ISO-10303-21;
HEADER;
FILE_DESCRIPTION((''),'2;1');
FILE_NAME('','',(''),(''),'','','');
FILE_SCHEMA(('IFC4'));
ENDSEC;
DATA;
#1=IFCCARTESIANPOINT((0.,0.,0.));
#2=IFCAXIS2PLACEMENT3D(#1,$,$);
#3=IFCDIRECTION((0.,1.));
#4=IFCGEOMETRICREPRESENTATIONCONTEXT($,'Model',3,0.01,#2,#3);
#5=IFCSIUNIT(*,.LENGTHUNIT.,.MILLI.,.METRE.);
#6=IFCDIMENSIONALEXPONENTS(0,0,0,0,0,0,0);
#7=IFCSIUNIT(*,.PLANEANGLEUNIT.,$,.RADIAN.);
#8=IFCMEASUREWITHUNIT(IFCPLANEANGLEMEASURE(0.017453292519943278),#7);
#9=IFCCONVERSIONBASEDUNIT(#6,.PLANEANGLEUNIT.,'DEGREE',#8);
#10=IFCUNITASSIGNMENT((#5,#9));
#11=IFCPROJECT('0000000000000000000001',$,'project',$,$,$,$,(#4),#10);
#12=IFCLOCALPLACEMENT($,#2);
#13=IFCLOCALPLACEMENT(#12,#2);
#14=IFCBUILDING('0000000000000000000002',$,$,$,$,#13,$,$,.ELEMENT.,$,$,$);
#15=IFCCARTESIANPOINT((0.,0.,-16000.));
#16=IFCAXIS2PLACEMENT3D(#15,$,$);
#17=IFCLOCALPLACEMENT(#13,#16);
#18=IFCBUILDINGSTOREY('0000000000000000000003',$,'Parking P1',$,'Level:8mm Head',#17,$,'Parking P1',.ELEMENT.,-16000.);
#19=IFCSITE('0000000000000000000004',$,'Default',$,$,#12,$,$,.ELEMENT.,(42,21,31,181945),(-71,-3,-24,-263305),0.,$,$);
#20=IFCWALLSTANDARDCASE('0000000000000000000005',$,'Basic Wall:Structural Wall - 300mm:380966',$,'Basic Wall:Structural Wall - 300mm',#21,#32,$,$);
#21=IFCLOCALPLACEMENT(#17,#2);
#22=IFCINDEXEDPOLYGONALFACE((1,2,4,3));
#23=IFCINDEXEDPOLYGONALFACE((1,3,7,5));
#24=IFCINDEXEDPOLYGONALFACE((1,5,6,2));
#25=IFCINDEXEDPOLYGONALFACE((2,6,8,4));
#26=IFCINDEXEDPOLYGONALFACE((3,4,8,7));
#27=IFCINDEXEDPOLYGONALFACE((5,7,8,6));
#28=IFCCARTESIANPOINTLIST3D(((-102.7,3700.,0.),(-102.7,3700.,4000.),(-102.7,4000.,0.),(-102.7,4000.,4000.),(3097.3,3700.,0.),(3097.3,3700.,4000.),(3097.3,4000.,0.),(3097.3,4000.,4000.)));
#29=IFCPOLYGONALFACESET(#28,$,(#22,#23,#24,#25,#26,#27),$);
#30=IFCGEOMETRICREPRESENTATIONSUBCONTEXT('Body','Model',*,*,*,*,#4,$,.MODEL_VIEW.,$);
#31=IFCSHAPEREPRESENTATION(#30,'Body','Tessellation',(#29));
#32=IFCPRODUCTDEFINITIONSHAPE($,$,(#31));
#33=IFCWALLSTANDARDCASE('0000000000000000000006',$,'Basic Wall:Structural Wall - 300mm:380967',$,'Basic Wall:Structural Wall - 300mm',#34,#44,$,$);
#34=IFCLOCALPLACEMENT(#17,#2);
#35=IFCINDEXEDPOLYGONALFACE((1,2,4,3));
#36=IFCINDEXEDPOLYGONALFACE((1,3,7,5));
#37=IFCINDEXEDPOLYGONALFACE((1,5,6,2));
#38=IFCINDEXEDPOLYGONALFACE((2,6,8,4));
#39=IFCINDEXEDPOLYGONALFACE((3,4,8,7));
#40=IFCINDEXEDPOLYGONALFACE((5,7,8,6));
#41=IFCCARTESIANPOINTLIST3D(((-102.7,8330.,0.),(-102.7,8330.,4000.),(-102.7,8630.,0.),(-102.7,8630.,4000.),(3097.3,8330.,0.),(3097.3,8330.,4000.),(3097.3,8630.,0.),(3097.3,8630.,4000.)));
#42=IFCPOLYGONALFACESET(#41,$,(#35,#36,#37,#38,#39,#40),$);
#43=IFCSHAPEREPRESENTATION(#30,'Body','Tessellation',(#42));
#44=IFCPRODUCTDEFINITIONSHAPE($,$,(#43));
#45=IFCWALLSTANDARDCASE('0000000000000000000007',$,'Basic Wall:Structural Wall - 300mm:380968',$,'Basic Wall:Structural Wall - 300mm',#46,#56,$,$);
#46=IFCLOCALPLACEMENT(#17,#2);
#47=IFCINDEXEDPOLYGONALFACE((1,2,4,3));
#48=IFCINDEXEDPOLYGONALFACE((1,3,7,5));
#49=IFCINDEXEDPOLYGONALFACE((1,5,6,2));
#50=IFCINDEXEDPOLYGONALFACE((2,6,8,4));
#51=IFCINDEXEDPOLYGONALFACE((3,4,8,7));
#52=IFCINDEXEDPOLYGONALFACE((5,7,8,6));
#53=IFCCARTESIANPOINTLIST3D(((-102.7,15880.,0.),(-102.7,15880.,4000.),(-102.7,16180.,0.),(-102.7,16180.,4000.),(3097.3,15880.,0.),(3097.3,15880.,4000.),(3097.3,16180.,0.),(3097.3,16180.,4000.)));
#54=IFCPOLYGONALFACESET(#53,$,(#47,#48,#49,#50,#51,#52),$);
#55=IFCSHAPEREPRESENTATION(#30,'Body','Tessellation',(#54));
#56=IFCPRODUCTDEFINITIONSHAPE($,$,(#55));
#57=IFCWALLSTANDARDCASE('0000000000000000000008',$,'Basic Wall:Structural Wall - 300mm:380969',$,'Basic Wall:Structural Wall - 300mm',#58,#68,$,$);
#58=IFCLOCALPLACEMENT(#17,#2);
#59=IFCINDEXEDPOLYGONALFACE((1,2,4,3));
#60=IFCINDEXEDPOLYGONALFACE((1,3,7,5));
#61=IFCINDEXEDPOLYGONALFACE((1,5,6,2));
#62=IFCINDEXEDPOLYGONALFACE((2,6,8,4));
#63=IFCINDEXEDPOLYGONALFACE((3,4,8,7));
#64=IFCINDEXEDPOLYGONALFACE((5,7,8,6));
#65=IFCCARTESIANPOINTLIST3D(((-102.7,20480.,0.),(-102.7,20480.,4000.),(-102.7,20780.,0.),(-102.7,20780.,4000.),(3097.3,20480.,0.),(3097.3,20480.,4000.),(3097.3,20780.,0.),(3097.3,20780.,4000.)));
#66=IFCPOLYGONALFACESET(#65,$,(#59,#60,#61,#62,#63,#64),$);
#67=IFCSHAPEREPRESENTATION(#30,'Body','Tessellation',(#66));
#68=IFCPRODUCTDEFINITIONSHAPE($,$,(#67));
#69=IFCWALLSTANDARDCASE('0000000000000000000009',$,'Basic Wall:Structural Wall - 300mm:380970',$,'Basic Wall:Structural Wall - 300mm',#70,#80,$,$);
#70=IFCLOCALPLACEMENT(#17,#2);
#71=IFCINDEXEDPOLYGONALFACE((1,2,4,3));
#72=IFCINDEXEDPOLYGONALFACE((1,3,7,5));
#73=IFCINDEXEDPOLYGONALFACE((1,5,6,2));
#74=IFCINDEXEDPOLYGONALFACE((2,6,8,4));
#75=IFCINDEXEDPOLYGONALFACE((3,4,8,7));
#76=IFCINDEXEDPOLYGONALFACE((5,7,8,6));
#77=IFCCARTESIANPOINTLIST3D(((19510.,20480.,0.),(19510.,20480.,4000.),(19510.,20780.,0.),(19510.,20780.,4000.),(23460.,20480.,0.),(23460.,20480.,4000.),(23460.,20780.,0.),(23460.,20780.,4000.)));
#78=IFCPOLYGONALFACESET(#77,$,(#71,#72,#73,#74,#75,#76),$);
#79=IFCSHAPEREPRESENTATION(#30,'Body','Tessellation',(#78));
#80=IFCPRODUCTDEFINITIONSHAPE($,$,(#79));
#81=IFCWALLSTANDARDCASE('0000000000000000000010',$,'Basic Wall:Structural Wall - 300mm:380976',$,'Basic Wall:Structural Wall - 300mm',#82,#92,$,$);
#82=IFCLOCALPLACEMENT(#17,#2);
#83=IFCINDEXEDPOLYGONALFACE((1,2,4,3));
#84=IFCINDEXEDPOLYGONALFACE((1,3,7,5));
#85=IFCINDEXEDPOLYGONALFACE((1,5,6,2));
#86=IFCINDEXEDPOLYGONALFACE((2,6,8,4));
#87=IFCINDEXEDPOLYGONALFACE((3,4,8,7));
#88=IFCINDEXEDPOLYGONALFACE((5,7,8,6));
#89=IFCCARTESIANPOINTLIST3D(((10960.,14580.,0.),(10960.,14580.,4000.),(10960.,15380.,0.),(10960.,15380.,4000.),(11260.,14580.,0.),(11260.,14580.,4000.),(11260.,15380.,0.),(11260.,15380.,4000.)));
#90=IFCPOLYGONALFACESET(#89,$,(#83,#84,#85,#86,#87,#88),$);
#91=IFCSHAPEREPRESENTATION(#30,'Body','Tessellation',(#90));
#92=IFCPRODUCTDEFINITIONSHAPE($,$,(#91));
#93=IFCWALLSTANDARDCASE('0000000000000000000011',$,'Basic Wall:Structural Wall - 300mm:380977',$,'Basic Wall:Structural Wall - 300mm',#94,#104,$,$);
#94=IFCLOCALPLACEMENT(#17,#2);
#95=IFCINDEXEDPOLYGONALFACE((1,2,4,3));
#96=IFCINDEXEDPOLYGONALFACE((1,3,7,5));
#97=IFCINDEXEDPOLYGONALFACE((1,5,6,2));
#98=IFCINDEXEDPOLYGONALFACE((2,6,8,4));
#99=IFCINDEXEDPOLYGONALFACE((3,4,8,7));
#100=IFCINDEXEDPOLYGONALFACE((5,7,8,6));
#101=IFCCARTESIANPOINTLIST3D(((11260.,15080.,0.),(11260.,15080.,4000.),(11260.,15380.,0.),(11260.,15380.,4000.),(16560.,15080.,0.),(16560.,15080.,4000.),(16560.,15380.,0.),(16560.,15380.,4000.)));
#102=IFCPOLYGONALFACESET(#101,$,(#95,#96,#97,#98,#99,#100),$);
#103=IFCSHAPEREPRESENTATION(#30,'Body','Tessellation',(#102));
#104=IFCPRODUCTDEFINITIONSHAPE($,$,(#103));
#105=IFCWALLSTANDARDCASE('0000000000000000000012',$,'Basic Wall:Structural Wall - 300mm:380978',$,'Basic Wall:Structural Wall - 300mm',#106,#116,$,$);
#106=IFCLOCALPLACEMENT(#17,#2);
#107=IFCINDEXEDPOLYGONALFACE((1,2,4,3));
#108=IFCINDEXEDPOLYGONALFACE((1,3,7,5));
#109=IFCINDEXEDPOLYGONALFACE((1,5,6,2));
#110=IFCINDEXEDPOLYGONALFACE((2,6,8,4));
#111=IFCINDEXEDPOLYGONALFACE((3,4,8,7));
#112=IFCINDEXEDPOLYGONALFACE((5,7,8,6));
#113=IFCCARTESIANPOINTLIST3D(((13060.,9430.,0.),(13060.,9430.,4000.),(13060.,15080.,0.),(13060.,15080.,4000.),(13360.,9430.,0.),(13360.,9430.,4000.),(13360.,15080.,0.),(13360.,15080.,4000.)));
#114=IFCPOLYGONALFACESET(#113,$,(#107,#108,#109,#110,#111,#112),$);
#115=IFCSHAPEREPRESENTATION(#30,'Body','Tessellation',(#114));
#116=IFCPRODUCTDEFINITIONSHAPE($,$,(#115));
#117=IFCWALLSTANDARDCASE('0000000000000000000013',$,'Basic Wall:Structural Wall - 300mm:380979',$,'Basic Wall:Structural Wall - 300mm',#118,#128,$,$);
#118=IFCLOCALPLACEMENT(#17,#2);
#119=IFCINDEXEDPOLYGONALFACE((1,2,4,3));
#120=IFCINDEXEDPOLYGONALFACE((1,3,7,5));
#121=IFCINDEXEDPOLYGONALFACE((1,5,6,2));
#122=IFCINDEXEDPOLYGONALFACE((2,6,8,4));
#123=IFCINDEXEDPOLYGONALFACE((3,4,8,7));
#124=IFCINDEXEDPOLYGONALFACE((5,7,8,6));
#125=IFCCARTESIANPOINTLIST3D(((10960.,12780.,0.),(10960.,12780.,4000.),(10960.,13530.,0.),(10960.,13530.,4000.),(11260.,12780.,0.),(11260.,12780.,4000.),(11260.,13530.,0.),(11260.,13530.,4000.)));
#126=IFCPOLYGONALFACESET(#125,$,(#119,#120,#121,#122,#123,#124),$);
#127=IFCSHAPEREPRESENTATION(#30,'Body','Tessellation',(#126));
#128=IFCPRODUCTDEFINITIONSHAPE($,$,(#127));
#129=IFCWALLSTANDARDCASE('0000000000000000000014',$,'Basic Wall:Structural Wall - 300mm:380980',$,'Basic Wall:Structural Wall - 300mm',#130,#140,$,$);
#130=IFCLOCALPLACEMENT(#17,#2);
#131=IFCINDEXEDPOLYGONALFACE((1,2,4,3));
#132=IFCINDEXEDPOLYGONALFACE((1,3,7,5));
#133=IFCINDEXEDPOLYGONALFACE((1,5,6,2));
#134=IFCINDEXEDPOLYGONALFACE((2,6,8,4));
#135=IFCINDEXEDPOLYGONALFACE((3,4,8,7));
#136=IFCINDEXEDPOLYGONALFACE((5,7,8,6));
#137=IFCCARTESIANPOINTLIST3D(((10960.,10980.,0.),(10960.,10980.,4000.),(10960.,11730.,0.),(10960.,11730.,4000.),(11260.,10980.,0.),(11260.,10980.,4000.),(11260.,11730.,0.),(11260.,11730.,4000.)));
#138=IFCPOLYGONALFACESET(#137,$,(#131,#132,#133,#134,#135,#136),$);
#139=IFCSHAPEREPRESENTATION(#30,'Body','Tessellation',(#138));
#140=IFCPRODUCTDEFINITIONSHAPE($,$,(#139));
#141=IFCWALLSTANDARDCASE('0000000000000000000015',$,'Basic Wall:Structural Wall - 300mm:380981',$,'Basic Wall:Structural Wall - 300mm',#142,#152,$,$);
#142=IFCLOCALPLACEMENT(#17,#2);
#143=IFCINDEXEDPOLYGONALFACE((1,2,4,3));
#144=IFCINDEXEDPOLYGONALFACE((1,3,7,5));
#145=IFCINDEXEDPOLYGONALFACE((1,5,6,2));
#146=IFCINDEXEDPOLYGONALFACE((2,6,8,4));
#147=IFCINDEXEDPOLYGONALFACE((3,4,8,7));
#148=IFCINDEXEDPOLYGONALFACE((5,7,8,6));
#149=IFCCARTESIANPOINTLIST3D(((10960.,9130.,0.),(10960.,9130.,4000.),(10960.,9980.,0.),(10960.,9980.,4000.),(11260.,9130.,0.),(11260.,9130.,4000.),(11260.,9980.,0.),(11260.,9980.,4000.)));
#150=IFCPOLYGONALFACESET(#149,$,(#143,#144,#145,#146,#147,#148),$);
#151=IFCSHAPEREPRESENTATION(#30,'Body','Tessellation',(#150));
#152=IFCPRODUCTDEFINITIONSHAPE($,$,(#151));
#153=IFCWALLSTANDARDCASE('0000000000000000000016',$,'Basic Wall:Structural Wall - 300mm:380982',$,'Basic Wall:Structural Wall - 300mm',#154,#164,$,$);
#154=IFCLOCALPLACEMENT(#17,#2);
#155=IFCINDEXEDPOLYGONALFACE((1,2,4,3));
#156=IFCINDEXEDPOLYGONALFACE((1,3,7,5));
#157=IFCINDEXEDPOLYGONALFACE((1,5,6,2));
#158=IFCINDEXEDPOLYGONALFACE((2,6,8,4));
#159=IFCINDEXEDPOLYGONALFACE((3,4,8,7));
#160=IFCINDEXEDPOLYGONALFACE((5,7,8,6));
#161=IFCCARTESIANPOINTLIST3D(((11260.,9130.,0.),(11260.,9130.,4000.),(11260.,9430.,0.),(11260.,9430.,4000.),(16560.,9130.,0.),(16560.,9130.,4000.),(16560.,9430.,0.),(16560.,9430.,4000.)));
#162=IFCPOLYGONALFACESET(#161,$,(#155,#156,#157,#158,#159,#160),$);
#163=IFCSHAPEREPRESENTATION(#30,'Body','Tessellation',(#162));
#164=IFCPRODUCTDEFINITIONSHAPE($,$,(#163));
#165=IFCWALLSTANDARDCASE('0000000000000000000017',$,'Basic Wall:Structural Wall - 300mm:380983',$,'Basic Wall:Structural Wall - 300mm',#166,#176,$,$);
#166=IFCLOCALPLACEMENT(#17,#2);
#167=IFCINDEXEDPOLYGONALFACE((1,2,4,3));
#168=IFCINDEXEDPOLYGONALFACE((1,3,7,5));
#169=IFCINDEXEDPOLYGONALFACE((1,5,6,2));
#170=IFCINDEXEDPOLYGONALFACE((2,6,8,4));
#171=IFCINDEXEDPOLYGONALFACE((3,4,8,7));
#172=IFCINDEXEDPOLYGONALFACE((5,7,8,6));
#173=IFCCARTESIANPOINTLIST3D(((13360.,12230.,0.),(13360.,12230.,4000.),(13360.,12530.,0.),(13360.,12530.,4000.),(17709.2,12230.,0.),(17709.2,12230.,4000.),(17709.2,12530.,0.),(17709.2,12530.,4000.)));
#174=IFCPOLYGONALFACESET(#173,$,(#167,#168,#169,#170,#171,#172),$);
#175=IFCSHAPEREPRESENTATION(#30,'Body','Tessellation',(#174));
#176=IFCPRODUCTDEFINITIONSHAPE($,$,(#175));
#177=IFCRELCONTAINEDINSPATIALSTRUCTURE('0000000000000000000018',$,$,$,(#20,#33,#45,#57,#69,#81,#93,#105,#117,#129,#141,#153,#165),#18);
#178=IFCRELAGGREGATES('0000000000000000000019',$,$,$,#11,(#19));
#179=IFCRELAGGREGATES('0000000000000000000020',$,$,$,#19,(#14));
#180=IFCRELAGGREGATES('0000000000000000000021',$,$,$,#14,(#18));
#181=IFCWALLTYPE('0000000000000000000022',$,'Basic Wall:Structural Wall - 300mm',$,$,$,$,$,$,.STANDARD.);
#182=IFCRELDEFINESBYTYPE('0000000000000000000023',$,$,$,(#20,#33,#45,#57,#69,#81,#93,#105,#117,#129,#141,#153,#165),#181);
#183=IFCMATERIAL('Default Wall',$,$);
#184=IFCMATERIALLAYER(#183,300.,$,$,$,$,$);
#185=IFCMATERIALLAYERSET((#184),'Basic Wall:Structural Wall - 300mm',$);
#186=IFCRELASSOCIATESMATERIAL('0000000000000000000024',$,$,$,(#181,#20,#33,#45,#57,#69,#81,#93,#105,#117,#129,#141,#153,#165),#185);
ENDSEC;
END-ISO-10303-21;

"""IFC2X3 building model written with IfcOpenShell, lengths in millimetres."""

from ifc_helpers import new_model, entity, si_unit, converted_unit, direction, frame, frame_2d, origin, place, context, subcontext, project, spatial, rectangle, extrude, material, layer, layer_set, layer_usage, type_object, element, save


model = new_model("IFC2X3")

# Units and contexts
model_context = context("Model", 3, precision=0.01, world=origin(), true_north=direction((0.0, 1.0)))
body_context = subcontext(model_context, "Body", "Model", "MODEL_VIEW")
ifc_project = project(units=[si_unit("LENGTHUNIT", "METRE", prefix="MILLI"), converted_unit("PLANEANGLEUNIT", "DEGREE", entity("IfcPlaneAngleMeasure", 0.017453292519943278), si_unit("PLANEANGLEUNIT", "RADIAN"), dimensions=[0, 0, 0, 0, 0, 0, 0])], contexts=[model_context])

# Site, building, storey
site_placement = place(None, origin())
site = spatial("IfcSite", under=ifc_project, at=site_placement, Name="Default", CompositionType="ELEMENT", RefLatitude=(42, 21, 31, 181945), RefLongitude=(-71, -3, -24, -263305), RefElevation=0.0)
building_placement = place(site_placement, origin())
building = spatial("IfcBuilding", under=site, at=building_placement, CompositionType="ELEMENT")
storey_placement = place(building_placement, frame((0.0, 0.0, -16000.0)))
storey = spatial("IfcBuildingStorey", under=building, at=storey_placement, Name="Parking P1", ObjectType="Level:8mm Head", LongName="Parking P1", CompositionType="ELEMENT", Elevation=-16000.0)

# Walls
ifc_material_1 = material(Name="Default Wall")
ifc_layer_1 = layer(ifc_material_1, 300.0)
ifc_layer_set_1 = layer_set([ifc_layer_1], Name="Basic Wall:Structural Wall - 300mm")
ifc_layer_usage_1 = layer_usage(ifc_layer_set_1, "AXIS2", "NEGATIVE", 150.0)
wall_type_1 = type_object("IfcWallType", Name="Basic Wall:Structural Wall - 300mm", PredefinedType="STANDARD", material=ifc_layer_set_1)
wall_1_placement = place(storey_placement, frame((3097.3, 3850.0, 0.0), z_axis=(0.0, 0.0, 1.0), x_axis=(-1.0, 0.0, 0.0)))
element("IfcWallStandardCase", 1, at=wall_1_placement, inside=storey, type_object=wall_type_1, material=ifc_layer_usage_1, Name="Basic Wall:Structural Wall - 300mm:380966", ObjectType="Basic Wall:Structural Wall - 300mm", context=body_context, shape_type="SweptSolid", body=[
    extrude(rectangle(XDim=3200.0, YDim=300.0, at=frame_2d((1600.0, 0.0), x_axis=(-1.0, 0.0))), origin(), (0.0, 0.0, 1.0), 4000.0),
])
ifc_layer_usage_2 = layer_usage(ifc_layer_set_1, "AXIS2", "NEGATIVE", 150.0)
wall_2_placement = place(storey_placement, frame((-102.7, 8480.0, 0.0)))
element("IfcWallStandardCase", 2, at=wall_2_placement, inside=storey, type_object=wall_type_1, material=ifc_layer_usage_2, Name="Basic Wall:Structural Wall - 300mm:380967", ObjectType="Basic Wall:Structural Wall - 300mm", context=body_context, shape_type="SweptSolid", body=[
    extrude(rectangle(XDim=3200.0, YDim=300.0, at=frame_2d((1600.0, 0.0), x_axis=(-1.0, 0.0))), origin(), (0.0, 0.0, 1.0), 4000.0),
])
ifc_layer_usage_3 = layer_usage(ifc_layer_set_1, "AXIS2", "NEGATIVE", 150.0)
wall_3_placement = place(storey_placement, frame((-102.7, 16030.0, 0.0)))
element("IfcWallStandardCase", 3, at=wall_3_placement, inside=storey, type_object=wall_type_1, material=ifc_layer_usage_3, Name="Basic Wall:Structural Wall - 300mm:380968", ObjectType="Basic Wall:Structural Wall - 300mm", context=body_context, shape_type="SweptSolid", body=[
    extrude(rectangle(XDim=3200.0, YDim=300.0, at=frame_2d((1600.0, 0.0), x_axis=(-1.0, 0.0))), origin(), (0.0, 0.0, 1.0), 4000.0),
])
ifc_layer_usage_4 = layer_usage(ifc_layer_set_1, "AXIS2", "NEGATIVE", 150.0)
wall_4_placement = place(storey_placement, frame((-102.7, 20630.0, 0.0)))
element("IfcWallStandardCase", 4, at=wall_4_placement, inside=storey, type_object=wall_type_1, material=ifc_layer_usage_4, Name="Basic Wall:Structural Wall - 300mm:380969", ObjectType="Basic Wall:Structural Wall - 300mm", context=body_context, shape_type="SweptSolid", body=[
    extrude(rectangle(XDim=3200.0, YDim=300.0, at=frame_2d((1600.0, 0.0), x_axis=(-1.0, 0.0))), origin(), (0.0, 0.0, 1.0), 4000.0),
])
ifc_layer_usage_5 = layer_usage(ifc_layer_set_1, "AXIS2", "NEGATIVE", 150.0)
wall_5_placement = place(storey_placement, frame((19510.0, 20630.0, 0.0)))
element("IfcWallStandardCase", 5, at=wall_5_placement, inside=storey, type_object=wall_type_1, material=ifc_layer_usage_5, Name="Basic Wall:Structural Wall - 300mm:380970", ObjectType="Basic Wall:Structural Wall - 300mm", context=body_context, shape_type="SweptSolid", body=[
    extrude(rectangle(XDim=3950.0, YDim=300.0, at=frame_2d((1975.0, 0.0), x_axis=(-1.0, 0.0))), origin(), (0.0, 0.0, 1.0), 4000.0),
])
ifc_layer_usage_6 = layer_usage(ifc_layer_set_1, "AXIS2", "NEGATIVE", 150.0)
wall_6_placement = place(storey_placement, frame((11110.0, 14580.0, 0.0), z_axis=(0.0, 0.0, 1.0), x_axis=(0.0, 1.0, 0.0)))
element("IfcWallStandardCase", 6, at=wall_6_placement, inside=storey, type_object=wall_type_1, material=ifc_layer_usage_6, Name="Basic Wall:Structural Wall - 300mm:380976", ObjectType="Basic Wall:Structural Wall - 300mm", context=body_context, shape_type="SweptSolid", body=[
    extrude(rectangle(XDim=800.0, YDim=300.0, at=frame_2d((400.0, 0.0), x_axis=(-1.0, 0.0))), origin(), (0.0, 0.0, 1.0), 4000.0),
])
ifc_layer_usage_7 = layer_usage(ifc_layer_set_1, "AXIS2", "NEGATIVE", 150.0)
wall_7_placement = place(storey_placement, frame((11260.0, 15230.0, 0.0)))
element("IfcWallStandardCase", 7, at=wall_7_placement, inside=storey, type_object=wall_type_1, material=ifc_layer_usage_7, Name="Basic Wall:Structural Wall - 300mm:380977", ObjectType="Basic Wall:Structural Wall - 300mm", context=body_context, shape_type="SweptSolid", body=[
    extrude(rectangle(XDim=5300.0, YDim=300.0, at=frame_2d((2650.0, 0.0), x_axis=(-1.0, 0.0))), origin(), (0.0, 0.0, 1.0), 4000.0),
])
ifc_layer_usage_8 = layer_usage(ifc_layer_set_1, "AXIS2", "NEGATIVE", 150.0)
wall_8_placement = place(storey_placement, frame((13210.0, 15080.0, 0.0), z_axis=(0.0, 0.0, 1.0), x_axis=(0.0, -1.0, 0.0)))
element("IfcWallStandardCase", 8, at=wall_8_placement, inside=storey, type_object=wall_type_1, material=ifc_layer_usage_8, Name="Basic Wall:Structural Wall - 300mm:380978", ObjectType="Basic Wall:Structural Wall - 300mm", context=body_context, shape_type="SweptSolid", body=[
    extrude(rectangle(XDim=5650.0, YDim=300.0, at=frame_2d((2825.0, 0.0), x_axis=(-1.0, 0.0))), origin(), (0.0, 0.0, 1.0), 4000.0),
])
ifc_layer_usage_9 = layer_usage(ifc_layer_set_1, "AXIS2", "NEGATIVE", 150.0)
wall_9_placement = place(storey_placement, frame((11110.0, 13530.0, 0.0), z_axis=(0.0, 0.0, 1.0), x_axis=(0.0, -1.0, 0.0)))
element("IfcWallStandardCase", 9, at=wall_9_placement, inside=storey, type_object=wall_type_1, material=ifc_layer_usage_9, Name="Basic Wall:Structural Wall - 300mm:380979", ObjectType="Basic Wall:Structural Wall - 300mm", context=body_context, shape_type="SweptSolid", body=[
    extrude(rectangle(XDim=750.0, YDim=300.0, at=frame_2d((375.0, 0.0), x_axis=(-1.0, 0.0))), origin(), (0.0, 0.0, 1.0), 4000.0),
])
ifc_layer_usage_10 = layer_usage(ifc_layer_set_1, "AXIS2", "NEGATIVE", 150.0)
wall_10_placement = place(storey_placement, frame((11110.0, 11730.0, 0.0), z_axis=(0.0, 0.0, 1.0), x_axis=(0.0, -1.0, 0.0)))
element("IfcWallStandardCase", 10, at=wall_10_placement, inside=storey, type_object=wall_type_1, material=ifc_layer_usage_10, Name="Basic Wall:Structural Wall - 300mm:380980", ObjectType="Basic Wall:Structural Wall - 300mm", context=body_context, shape_type="SweptSolid", body=[
    extrude(rectangle(XDim=750.0, YDim=300.0, at=frame_2d((375.0, 0.0), x_axis=(-1.0, 0.0))), origin(), (0.0, 0.0, 1.0), 4000.0),
])
ifc_layer_usage_11 = layer_usage(ifc_layer_set_1, "AXIS2", "NEGATIVE", 150.0)
wall_11_placement = place(storey_placement, frame((11110.0, 9980.0, 0.0), z_axis=(0.0, 0.0, 1.0), x_axis=(0.0, -1.0, 0.0)))
element("IfcWallStandardCase", 11, at=wall_11_placement, inside=storey, type_object=wall_type_1, material=ifc_layer_usage_11, Name="Basic Wall:Structural Wall - 300mm:380981", ObjectType="Basic Wall:Structural Wall - 300mm", context=body_context, shape_type="SweptSolid", body=[
    extrude(rectangle(XDim=850.0, YDim=300.0, at=frame_2d((425.0, 0.0), x_axis=(-1.0, 0.0))), origin(), (0.0, 0.0, 1.0), 4000.0),
])
ifc_layer_usage_12 = layer_usage(ifc_layer_set_1, "AXIS2", "NEGATIVE", 150.0)
wall_12_placement = place(storey_placement, frame((11260.0, 9280.0, 0.0)))
element("IfcWallStandardCase", 12, at=wall_12_placement, inside=storey, type_object=wall_type_1, material=ifc_layer_usage_12, Name="Basic Wall:Structural Wall - 300mm:380982", ObjectType="Basic Wall:Structural Wall - 300mm", context=body_context, shape_type="SweptSolid", body=[
    extrude(rectangle(XDim=5300.0, YDim=300.0, at=frame_2d((2650.0, 0.0), x_axis=(-1.0, 0.0))), origin(), (0.0, 0.0, 1.0), 4000.0),
])
ifc_layer_usage_13 = layer_usage(ifc_layer_set_1, "AXIS2", "NEGATIVE", 150.0)
wall_13_placement = place(storey_placement, frame((13360.0, 12380.0, 0.0)))
element("IfcWallStandardCase", 13, at=wall_13_placement, inside=storey, type_object=wall_type_1, material=ifc_layer_usage_13, Name="Basic Wall:Structural Wall - 300mm:380983", ObjectType="Basic Wall:Structural Wall - 300mm", context=body_context, shape_type="SweptSolid", body=[
    extrude(rectangle(XDim=4349.2, YDim=300.0, at=frame_2d((2174.6, 0.0), x_axis=(-1.0, 0.0))), origin(), (0.0, 0.0, 1.0), 4000.0),
])

save(model, "model.ifc")
